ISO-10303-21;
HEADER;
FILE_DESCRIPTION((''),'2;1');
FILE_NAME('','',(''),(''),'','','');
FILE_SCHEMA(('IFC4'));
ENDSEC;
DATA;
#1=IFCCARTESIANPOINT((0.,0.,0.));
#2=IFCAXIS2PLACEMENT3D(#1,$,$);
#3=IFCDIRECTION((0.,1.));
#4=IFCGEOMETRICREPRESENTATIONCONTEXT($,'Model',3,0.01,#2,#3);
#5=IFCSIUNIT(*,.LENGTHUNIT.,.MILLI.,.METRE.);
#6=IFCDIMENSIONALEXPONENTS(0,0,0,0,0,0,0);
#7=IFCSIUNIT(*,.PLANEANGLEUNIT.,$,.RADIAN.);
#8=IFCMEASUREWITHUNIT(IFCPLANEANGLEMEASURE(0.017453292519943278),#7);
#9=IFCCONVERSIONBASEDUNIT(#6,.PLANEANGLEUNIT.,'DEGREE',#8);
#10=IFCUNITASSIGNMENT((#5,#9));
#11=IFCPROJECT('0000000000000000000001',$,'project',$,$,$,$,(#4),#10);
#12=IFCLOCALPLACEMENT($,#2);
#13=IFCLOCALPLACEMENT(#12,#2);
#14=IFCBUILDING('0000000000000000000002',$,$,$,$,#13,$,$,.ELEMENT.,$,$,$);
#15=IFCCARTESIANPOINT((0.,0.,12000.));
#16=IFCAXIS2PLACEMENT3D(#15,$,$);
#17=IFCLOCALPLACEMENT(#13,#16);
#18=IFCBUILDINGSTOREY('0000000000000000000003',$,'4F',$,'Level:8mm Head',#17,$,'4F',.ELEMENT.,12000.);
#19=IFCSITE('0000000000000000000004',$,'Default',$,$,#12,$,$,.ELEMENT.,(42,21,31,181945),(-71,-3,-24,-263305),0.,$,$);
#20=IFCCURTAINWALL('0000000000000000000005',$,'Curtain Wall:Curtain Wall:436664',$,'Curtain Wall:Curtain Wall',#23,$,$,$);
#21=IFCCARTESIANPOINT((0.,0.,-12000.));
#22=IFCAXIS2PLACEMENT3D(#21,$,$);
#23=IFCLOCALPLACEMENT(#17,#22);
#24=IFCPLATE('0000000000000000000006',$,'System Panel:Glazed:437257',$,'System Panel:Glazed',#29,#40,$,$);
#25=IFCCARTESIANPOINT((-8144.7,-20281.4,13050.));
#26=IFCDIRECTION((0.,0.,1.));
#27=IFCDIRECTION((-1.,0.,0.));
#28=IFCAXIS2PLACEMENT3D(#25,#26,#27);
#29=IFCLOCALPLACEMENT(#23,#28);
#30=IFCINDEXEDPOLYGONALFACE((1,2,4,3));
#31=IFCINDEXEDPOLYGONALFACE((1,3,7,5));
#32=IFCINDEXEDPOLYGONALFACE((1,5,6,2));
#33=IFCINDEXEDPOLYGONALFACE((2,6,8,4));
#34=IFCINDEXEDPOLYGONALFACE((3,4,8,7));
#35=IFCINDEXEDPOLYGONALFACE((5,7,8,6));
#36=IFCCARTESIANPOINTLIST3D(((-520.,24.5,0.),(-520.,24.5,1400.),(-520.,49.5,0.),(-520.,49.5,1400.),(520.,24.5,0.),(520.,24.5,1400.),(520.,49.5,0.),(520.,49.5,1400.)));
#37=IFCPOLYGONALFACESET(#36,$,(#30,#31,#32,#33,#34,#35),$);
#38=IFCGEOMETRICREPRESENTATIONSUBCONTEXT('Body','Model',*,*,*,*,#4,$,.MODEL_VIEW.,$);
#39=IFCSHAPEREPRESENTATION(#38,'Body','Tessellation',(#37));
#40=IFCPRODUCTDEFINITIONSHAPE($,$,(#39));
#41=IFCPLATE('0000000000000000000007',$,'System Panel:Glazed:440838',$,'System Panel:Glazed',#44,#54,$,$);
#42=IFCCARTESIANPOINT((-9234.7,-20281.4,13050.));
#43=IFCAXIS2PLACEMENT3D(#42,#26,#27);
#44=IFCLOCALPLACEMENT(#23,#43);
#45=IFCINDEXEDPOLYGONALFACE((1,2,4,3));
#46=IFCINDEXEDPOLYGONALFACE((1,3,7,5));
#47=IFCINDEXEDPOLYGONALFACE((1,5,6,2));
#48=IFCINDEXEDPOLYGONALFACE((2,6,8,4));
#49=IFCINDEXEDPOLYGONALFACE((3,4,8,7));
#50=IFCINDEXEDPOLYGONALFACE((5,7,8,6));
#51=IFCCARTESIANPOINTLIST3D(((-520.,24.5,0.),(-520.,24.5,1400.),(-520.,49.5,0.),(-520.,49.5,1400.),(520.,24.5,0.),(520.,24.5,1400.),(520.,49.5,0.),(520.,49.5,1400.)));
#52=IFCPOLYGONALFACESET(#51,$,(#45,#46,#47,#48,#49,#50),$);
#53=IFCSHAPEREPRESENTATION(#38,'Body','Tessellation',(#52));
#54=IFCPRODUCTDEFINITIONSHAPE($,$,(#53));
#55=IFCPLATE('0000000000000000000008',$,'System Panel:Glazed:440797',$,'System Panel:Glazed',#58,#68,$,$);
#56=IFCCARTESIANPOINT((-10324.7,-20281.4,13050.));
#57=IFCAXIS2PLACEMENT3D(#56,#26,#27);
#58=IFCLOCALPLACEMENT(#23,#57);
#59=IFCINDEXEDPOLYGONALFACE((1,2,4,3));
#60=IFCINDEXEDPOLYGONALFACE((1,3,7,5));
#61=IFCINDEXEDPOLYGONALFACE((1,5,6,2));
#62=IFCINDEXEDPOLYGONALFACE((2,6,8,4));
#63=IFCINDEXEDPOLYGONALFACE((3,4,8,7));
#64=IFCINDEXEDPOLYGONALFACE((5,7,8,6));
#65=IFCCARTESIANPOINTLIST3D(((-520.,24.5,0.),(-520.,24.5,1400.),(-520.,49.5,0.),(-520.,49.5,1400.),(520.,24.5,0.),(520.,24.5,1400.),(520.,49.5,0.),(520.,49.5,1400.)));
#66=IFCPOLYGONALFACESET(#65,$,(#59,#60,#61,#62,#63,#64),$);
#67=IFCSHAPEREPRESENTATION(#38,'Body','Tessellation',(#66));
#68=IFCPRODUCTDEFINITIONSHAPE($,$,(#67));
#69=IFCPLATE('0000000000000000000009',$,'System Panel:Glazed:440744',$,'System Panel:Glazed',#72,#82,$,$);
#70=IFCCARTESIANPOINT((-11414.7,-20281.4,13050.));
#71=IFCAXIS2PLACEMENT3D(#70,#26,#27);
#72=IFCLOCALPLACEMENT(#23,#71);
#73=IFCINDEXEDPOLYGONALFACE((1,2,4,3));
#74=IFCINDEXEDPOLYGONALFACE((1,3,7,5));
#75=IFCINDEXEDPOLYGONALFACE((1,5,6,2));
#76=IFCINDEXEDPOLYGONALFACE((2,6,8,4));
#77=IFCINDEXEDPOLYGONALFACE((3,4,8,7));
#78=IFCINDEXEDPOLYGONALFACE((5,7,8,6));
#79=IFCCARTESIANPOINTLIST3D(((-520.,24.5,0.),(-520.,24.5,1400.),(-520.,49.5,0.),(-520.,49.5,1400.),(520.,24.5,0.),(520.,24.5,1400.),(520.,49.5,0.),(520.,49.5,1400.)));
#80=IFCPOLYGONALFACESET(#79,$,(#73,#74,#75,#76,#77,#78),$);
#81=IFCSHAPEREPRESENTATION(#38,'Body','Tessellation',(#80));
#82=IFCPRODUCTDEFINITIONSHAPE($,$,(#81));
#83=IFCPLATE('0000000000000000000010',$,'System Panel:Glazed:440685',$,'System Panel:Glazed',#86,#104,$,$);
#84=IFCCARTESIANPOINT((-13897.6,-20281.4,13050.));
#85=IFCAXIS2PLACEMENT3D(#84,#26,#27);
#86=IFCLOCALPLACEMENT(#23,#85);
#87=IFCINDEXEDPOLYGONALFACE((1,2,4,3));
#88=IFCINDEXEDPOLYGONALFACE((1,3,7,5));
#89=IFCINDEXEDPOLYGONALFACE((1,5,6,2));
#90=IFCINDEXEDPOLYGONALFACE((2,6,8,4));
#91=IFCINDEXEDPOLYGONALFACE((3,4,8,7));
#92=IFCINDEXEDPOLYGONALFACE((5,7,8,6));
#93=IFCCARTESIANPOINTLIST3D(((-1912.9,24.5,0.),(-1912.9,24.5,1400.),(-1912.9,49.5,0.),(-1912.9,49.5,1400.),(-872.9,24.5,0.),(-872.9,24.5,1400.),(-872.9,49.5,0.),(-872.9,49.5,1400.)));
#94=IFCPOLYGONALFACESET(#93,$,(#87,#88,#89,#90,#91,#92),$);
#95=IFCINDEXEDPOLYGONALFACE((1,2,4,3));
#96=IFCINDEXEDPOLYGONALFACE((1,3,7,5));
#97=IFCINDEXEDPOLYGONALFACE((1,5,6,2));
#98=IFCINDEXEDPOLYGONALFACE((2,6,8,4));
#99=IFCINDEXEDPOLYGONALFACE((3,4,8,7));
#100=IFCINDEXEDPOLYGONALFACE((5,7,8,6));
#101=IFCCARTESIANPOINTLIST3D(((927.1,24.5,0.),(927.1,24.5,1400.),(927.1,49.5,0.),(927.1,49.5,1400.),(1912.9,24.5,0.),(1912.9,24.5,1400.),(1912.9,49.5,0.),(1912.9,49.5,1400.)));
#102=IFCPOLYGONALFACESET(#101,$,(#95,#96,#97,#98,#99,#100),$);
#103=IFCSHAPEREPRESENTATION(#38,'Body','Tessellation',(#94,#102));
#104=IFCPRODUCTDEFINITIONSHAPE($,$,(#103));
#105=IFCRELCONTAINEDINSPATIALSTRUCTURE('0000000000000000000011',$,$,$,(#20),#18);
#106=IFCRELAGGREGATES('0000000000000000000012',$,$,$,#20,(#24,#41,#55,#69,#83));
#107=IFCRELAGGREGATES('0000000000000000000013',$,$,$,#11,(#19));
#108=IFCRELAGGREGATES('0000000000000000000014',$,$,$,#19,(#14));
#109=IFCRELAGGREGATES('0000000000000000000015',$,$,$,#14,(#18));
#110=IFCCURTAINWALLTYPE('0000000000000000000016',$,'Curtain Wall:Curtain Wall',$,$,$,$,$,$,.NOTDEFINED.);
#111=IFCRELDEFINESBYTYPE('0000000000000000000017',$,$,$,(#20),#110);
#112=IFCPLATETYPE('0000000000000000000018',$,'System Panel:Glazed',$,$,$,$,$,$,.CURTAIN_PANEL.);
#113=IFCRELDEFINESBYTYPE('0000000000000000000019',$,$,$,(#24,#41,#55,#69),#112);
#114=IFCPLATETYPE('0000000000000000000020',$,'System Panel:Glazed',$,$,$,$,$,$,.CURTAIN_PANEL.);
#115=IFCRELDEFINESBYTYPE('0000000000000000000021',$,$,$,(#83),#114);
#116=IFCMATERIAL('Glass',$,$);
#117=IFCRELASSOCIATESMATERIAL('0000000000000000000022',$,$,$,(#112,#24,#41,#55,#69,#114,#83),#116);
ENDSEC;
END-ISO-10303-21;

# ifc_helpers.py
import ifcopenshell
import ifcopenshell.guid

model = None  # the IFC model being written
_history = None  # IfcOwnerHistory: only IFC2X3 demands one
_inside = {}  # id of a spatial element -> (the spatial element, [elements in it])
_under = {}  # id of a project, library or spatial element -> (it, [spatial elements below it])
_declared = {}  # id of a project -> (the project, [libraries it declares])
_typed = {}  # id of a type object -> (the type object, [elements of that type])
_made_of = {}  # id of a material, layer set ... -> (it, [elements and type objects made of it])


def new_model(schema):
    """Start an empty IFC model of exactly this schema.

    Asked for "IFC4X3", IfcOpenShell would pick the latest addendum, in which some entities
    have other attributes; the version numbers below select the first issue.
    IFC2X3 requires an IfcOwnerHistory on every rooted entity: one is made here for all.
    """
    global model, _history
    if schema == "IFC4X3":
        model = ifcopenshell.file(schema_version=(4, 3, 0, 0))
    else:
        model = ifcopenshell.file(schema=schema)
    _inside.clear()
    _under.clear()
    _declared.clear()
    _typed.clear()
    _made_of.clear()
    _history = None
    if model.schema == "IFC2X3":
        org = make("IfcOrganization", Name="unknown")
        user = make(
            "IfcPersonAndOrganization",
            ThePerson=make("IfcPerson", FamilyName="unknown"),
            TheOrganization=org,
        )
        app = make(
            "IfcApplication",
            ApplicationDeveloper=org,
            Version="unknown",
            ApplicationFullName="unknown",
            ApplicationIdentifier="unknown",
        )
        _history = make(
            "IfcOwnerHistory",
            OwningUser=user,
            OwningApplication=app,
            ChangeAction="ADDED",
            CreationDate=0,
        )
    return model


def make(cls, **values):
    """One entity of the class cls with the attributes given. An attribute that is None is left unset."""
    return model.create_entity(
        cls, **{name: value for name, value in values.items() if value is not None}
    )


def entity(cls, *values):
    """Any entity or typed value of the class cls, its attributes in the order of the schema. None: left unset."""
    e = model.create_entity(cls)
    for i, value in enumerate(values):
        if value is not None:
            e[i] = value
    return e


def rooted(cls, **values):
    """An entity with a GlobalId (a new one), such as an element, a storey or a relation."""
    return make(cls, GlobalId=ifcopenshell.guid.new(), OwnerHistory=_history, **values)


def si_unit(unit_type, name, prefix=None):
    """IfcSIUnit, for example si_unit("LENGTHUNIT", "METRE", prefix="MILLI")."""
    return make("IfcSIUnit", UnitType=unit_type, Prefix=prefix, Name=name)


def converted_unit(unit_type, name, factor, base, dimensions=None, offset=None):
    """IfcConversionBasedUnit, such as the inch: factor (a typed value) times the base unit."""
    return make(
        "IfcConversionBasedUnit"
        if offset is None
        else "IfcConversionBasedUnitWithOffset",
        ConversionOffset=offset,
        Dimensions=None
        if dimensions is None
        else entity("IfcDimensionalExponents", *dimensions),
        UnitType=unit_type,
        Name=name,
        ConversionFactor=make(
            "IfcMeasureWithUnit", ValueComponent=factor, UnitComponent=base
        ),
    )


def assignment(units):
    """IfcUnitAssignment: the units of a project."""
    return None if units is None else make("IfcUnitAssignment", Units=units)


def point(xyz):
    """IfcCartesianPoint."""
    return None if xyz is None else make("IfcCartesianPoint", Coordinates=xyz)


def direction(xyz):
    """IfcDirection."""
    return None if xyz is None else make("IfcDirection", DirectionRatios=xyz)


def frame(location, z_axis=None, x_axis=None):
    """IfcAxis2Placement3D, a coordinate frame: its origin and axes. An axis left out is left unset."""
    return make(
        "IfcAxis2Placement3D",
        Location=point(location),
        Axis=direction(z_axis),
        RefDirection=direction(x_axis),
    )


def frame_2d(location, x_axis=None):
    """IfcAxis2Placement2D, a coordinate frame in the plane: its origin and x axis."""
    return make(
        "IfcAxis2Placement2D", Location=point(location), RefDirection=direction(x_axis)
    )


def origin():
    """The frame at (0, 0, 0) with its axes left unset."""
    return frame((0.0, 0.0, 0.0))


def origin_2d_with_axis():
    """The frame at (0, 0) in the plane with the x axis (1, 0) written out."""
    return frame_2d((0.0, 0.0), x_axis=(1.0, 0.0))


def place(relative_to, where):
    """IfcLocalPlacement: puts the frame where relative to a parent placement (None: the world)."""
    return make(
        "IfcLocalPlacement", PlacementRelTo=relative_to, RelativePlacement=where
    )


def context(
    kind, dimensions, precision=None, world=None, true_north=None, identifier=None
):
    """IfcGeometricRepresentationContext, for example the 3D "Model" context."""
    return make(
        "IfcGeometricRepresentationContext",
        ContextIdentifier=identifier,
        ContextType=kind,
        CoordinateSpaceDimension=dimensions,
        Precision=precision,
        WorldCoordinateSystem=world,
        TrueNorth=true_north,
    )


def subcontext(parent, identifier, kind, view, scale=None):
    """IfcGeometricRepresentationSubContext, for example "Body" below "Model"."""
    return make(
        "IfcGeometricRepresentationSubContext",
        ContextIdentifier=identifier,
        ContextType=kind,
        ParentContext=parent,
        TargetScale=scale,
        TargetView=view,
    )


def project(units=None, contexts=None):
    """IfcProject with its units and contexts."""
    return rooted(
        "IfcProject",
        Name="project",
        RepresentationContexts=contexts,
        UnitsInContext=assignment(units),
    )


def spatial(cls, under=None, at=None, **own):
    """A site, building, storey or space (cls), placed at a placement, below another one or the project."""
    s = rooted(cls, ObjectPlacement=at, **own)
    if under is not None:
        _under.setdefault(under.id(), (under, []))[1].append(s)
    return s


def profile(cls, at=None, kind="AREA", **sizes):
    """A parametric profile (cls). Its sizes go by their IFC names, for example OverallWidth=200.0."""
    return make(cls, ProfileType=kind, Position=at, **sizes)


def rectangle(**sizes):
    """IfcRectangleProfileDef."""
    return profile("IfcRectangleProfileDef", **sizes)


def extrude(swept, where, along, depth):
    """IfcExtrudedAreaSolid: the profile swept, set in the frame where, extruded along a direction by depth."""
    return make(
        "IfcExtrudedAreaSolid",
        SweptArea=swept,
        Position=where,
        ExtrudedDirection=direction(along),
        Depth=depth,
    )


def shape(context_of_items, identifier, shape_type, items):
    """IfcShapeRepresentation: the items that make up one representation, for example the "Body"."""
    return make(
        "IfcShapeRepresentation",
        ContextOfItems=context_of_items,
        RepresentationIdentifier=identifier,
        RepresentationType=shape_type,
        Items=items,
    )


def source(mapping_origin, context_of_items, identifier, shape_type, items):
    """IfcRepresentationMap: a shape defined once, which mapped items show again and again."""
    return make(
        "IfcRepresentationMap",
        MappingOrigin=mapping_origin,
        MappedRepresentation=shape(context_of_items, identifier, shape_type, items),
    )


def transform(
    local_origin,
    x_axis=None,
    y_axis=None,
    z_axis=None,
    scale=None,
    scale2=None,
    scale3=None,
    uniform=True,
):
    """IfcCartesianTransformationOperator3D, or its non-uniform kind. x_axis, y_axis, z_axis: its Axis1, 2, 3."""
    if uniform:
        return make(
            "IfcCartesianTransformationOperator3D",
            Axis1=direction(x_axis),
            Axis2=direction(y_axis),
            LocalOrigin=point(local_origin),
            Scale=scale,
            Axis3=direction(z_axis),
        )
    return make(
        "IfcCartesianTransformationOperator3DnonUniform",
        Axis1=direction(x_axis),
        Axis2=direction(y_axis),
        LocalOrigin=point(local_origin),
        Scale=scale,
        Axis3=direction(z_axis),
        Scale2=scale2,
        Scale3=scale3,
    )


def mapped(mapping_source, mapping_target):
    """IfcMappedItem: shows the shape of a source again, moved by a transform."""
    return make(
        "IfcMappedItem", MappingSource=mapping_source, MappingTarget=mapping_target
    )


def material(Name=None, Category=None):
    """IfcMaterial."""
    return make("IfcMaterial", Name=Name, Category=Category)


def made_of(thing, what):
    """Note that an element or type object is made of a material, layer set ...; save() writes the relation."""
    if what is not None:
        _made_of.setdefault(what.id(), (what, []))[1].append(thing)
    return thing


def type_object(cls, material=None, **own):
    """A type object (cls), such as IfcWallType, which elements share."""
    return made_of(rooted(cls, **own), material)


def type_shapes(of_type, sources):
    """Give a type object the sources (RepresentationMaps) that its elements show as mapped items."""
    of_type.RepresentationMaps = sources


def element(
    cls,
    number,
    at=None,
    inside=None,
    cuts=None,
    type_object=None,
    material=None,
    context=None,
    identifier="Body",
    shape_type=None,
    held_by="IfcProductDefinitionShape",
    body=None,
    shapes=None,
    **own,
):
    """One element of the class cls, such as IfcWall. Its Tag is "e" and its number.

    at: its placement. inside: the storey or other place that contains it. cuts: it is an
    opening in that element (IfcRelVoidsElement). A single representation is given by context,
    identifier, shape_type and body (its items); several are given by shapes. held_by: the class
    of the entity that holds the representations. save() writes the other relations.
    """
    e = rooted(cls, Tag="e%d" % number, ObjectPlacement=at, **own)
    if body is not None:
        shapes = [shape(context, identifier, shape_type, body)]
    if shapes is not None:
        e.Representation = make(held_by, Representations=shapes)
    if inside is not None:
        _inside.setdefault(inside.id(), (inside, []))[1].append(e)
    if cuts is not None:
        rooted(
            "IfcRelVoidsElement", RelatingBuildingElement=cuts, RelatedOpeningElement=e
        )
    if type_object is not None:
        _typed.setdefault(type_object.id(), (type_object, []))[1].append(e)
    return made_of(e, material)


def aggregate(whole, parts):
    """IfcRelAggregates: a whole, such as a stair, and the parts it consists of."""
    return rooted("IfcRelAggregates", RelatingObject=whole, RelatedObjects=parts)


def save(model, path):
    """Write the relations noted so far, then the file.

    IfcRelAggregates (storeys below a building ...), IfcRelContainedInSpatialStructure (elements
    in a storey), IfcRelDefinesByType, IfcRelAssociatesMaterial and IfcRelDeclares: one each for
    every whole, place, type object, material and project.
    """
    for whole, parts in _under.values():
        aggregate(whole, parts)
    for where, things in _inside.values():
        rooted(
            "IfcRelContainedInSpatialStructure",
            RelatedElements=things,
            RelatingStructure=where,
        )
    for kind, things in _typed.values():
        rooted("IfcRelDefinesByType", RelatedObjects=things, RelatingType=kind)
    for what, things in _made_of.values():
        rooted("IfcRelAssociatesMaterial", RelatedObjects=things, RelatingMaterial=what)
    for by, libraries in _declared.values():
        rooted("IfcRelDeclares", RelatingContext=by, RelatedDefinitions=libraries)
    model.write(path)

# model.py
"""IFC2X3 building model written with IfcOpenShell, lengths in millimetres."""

from ifc_helpers import new_model, entity, si_unit, converted_unit, direction, frame, origin, origin_2d_with_axis, place, context, subcontext, project, spatial, rectangle, extrude, source, transform, mapped, material, type_object, type_shapes, element, aggregate, save


model = new_model("IFC2X3")

# Units and contexts
model_context = context("Model", 3, precision=0.01, world=origin(), true_north=direction((0.0, 1.0)))
body_context = subcontext(model_context, "Body", "Model", "MODEL_VIEW")
ifc_project = project(units=[si_unit("LENGTHUNIT", "METRE", prefix="MILLI"), converted_unit("PLANEANGLEUNIT", "DEGREE", entity("IfcPlaneAngleMeasure", 0.017453292519943278), si_unit("PLANEANGLEUNIT", "RADIAN"), dimensions=[0, 0, 0, 0, 0, 0, 0])], contexts=[model_context])

# Site, building, storey
site_placement = place(None, origin())
site = spatial("IfcSite", under=ifc_project, at=site_placement, Name="Default", CompositionType="ELEMENT", RefLatitude=(42, 21, 31, 181945), RefLongitude=(-71, -3, -24, -263305), RefElevation=0.0)
building_placement = place(site_placement, origin())
building = spatial("IfcBuilding", under=site, at=building_placement, CompositionType="ELEMENT")
storey_placement = place(building_placement, frame((0.0, 0.0, 12000.0)))
storey = spatial("IfcBuildingStorey", under=building, at=storey_placement, Name="4F", ObjectType="Level:8mm Head", LongName="4F", CompositionType="ELEMENT", Elevation=12000.0)

# Curtain wall, plates
curtain_wall_type = type_object("IfcCurtainWallType", Name="Curtain Wall:Curtain Wall", PredefinedType="NOTDEFINED")
curtain_wall_placement = place(storey_placement, frame((0.0, 0.0, -12000.0)))
curtain_wall = element("IfcCurtainWall", 1, at=curtain_wall_placement, inside=storey, type_object=curtain_wall_type, Name="Curtain Wall:Curtain Wall:436664", ObjectType="Curtain Wall:Curtain Wall")
ifc_material_1 = material(Name="Glass")
plate_type_1 = type_object("IfcPlateType", Name="System Panel:Glazed", PredefinedType="CURTAIN_PANEL", material=ifc_material_1)
shared_shape_1 = source(origin(), body_context, "Body", "SweptSolid", [
    extrude(rectangle(XDim=25.0, YDim=1040.0, at=origin_2d_with_axis()), frame((0.0, 37.0, 0.0), z_axis=(0.0, 0.0, 1.0), x_axis=(0.0, 1.0, 0.0)), (0.0, 0.0, 1.0), 1400.0),
])
type_shapes(plate_type_1, [shared_shape_1])
plate_1_placement = place(curtain_wall_placement, frame((-8144.7, -20281.4, 13050.0), z_axis=(0.0, 0.0, 1.0), x_axis=(-1.0, 0.0, 0.0)))
plate_1 = element("IfcPlate", 2, at=plate_1_placement, type_object=plate_type_1, material=ifc_material_1, Name="System Panel:Glazed:437257", ObjectType="System Panel:Glazed", context=body_context, shape_type="MappedRepresentation", body=[
    mapped(shared_shape_1, transform((0.0, 0.0, 0.0), scale=1.0)),
])
plate_2_placement = place(curtain_wall_placement, frame((-9234.7, -20281.4, 13050.0), z_axis=(0.0, 0.0, 1.0), x_axis=(-1.0, 0.0, 0.0)))
plate_2 = element("IfcPlate", 3, at=plate_2_placement, type_object=plate_type_1, material=ifc_material_1, Name="System Panel:Glazed:440838", ObjectType="System Panel:Glazed", context=body_context, shape_type="MappedRepresentation", body=[
    mapped(shared_shape_1, transform((0.0, 0.0, 0.0), scale=1.0)),
])
plate_3_placement = place(curtain_wall_placement, frame((-10324.7, -20281.4, 13050.0), z_axis=(0.0, 0.0, 1.0), x_axis=(-1.0, 0.0, 0.0)))
plate_3 = element("IfcPlate", 4, at=plate_3_placement, type_object=plate_type_1, material=ifc_material_1, Name="System Panel:Glazed:440797", ObjectType="System Panel:Glazed", context=body_context, shape_type="MappedRepresentation", body=[
    mapped(shared_shape_1, transform((0.0, 0.0, 0.0), scale=1.0)),
])
plate_4_placement = place(curtain_wall_placement, frame((-11414.7, -20281.4, 13050.0), z_axis=(0.0, 0.0, 1.0), x_axis=(-1.0, 0.0, 0.0)))
plate_4 = element("IfcPlate", 5, at=plate_4_placement, type_object=plate_type_1, material=ifc_material_1, Name="System Panel:Glazed:440744", ObjectType="System Panel:Glazed", context=body_context, shape_type="MappedRepresentation", body=[
    mapped(shared_shape_1, transform((0.0, 0.0, 0.0), scale=1.0)),
])
plate_type_2 = type_object("IfcPlateType", Name="System Panel:Glazed", PredefinedType="CURTAIN_PANEL", material=ifc_material_1)
shared_shape_2 = source(origin(), body_context, "Body", "SweptSolid", [
    extrude(rectangle(XDim=25.0, YDim=1040.0, at=origin_2d_with_axis()), frame((-1392.9, 37.0, 0.0), z_axis=(0.0, 0.0, 1.0), x_axis=(0.0, 1.0, 0.0)), (0.0, 0.0, 1.0), 1400.0),
    extrude(rectangle(XDim=25.0, YDim=985.7, at=origin_2d_with_axis()), frame((1420.0, 37.0, 0.0), z_axis=(0.0, 0.0, 1.0), x_axis=(0.0, 1.0, 0.0)), (0.0, 0.0, 1.0), 1400.0),
])
type_shapes(plate_type_2, [shared_shape_2])
plate_5_placement = place(curtain_wall_placement, frame((-13897.6, -20281.4, 13050.0), z_axis=(0.0, 0.0, 1.0), x_axis=(-1.0, 0.0, 0.0)))
plate_5 = element("IfcPlate", 6, at=plate_5_placement, type_object=plate_type_2, material=ifc_material_1, Name="System Panel:Glazed:440685", ObjectType="System Panel:Glazed", context=body_context, shape_type="MappedRepresentation", body=[
    mapped(shared_shape_2, transform((0.0, 0.0, 0.0), scale=1.0)),
])
aggregate(curtain_wall, [plate_1, plate_2, plate_3, plate_4, plate_5])

save(model, "model.ifc")
